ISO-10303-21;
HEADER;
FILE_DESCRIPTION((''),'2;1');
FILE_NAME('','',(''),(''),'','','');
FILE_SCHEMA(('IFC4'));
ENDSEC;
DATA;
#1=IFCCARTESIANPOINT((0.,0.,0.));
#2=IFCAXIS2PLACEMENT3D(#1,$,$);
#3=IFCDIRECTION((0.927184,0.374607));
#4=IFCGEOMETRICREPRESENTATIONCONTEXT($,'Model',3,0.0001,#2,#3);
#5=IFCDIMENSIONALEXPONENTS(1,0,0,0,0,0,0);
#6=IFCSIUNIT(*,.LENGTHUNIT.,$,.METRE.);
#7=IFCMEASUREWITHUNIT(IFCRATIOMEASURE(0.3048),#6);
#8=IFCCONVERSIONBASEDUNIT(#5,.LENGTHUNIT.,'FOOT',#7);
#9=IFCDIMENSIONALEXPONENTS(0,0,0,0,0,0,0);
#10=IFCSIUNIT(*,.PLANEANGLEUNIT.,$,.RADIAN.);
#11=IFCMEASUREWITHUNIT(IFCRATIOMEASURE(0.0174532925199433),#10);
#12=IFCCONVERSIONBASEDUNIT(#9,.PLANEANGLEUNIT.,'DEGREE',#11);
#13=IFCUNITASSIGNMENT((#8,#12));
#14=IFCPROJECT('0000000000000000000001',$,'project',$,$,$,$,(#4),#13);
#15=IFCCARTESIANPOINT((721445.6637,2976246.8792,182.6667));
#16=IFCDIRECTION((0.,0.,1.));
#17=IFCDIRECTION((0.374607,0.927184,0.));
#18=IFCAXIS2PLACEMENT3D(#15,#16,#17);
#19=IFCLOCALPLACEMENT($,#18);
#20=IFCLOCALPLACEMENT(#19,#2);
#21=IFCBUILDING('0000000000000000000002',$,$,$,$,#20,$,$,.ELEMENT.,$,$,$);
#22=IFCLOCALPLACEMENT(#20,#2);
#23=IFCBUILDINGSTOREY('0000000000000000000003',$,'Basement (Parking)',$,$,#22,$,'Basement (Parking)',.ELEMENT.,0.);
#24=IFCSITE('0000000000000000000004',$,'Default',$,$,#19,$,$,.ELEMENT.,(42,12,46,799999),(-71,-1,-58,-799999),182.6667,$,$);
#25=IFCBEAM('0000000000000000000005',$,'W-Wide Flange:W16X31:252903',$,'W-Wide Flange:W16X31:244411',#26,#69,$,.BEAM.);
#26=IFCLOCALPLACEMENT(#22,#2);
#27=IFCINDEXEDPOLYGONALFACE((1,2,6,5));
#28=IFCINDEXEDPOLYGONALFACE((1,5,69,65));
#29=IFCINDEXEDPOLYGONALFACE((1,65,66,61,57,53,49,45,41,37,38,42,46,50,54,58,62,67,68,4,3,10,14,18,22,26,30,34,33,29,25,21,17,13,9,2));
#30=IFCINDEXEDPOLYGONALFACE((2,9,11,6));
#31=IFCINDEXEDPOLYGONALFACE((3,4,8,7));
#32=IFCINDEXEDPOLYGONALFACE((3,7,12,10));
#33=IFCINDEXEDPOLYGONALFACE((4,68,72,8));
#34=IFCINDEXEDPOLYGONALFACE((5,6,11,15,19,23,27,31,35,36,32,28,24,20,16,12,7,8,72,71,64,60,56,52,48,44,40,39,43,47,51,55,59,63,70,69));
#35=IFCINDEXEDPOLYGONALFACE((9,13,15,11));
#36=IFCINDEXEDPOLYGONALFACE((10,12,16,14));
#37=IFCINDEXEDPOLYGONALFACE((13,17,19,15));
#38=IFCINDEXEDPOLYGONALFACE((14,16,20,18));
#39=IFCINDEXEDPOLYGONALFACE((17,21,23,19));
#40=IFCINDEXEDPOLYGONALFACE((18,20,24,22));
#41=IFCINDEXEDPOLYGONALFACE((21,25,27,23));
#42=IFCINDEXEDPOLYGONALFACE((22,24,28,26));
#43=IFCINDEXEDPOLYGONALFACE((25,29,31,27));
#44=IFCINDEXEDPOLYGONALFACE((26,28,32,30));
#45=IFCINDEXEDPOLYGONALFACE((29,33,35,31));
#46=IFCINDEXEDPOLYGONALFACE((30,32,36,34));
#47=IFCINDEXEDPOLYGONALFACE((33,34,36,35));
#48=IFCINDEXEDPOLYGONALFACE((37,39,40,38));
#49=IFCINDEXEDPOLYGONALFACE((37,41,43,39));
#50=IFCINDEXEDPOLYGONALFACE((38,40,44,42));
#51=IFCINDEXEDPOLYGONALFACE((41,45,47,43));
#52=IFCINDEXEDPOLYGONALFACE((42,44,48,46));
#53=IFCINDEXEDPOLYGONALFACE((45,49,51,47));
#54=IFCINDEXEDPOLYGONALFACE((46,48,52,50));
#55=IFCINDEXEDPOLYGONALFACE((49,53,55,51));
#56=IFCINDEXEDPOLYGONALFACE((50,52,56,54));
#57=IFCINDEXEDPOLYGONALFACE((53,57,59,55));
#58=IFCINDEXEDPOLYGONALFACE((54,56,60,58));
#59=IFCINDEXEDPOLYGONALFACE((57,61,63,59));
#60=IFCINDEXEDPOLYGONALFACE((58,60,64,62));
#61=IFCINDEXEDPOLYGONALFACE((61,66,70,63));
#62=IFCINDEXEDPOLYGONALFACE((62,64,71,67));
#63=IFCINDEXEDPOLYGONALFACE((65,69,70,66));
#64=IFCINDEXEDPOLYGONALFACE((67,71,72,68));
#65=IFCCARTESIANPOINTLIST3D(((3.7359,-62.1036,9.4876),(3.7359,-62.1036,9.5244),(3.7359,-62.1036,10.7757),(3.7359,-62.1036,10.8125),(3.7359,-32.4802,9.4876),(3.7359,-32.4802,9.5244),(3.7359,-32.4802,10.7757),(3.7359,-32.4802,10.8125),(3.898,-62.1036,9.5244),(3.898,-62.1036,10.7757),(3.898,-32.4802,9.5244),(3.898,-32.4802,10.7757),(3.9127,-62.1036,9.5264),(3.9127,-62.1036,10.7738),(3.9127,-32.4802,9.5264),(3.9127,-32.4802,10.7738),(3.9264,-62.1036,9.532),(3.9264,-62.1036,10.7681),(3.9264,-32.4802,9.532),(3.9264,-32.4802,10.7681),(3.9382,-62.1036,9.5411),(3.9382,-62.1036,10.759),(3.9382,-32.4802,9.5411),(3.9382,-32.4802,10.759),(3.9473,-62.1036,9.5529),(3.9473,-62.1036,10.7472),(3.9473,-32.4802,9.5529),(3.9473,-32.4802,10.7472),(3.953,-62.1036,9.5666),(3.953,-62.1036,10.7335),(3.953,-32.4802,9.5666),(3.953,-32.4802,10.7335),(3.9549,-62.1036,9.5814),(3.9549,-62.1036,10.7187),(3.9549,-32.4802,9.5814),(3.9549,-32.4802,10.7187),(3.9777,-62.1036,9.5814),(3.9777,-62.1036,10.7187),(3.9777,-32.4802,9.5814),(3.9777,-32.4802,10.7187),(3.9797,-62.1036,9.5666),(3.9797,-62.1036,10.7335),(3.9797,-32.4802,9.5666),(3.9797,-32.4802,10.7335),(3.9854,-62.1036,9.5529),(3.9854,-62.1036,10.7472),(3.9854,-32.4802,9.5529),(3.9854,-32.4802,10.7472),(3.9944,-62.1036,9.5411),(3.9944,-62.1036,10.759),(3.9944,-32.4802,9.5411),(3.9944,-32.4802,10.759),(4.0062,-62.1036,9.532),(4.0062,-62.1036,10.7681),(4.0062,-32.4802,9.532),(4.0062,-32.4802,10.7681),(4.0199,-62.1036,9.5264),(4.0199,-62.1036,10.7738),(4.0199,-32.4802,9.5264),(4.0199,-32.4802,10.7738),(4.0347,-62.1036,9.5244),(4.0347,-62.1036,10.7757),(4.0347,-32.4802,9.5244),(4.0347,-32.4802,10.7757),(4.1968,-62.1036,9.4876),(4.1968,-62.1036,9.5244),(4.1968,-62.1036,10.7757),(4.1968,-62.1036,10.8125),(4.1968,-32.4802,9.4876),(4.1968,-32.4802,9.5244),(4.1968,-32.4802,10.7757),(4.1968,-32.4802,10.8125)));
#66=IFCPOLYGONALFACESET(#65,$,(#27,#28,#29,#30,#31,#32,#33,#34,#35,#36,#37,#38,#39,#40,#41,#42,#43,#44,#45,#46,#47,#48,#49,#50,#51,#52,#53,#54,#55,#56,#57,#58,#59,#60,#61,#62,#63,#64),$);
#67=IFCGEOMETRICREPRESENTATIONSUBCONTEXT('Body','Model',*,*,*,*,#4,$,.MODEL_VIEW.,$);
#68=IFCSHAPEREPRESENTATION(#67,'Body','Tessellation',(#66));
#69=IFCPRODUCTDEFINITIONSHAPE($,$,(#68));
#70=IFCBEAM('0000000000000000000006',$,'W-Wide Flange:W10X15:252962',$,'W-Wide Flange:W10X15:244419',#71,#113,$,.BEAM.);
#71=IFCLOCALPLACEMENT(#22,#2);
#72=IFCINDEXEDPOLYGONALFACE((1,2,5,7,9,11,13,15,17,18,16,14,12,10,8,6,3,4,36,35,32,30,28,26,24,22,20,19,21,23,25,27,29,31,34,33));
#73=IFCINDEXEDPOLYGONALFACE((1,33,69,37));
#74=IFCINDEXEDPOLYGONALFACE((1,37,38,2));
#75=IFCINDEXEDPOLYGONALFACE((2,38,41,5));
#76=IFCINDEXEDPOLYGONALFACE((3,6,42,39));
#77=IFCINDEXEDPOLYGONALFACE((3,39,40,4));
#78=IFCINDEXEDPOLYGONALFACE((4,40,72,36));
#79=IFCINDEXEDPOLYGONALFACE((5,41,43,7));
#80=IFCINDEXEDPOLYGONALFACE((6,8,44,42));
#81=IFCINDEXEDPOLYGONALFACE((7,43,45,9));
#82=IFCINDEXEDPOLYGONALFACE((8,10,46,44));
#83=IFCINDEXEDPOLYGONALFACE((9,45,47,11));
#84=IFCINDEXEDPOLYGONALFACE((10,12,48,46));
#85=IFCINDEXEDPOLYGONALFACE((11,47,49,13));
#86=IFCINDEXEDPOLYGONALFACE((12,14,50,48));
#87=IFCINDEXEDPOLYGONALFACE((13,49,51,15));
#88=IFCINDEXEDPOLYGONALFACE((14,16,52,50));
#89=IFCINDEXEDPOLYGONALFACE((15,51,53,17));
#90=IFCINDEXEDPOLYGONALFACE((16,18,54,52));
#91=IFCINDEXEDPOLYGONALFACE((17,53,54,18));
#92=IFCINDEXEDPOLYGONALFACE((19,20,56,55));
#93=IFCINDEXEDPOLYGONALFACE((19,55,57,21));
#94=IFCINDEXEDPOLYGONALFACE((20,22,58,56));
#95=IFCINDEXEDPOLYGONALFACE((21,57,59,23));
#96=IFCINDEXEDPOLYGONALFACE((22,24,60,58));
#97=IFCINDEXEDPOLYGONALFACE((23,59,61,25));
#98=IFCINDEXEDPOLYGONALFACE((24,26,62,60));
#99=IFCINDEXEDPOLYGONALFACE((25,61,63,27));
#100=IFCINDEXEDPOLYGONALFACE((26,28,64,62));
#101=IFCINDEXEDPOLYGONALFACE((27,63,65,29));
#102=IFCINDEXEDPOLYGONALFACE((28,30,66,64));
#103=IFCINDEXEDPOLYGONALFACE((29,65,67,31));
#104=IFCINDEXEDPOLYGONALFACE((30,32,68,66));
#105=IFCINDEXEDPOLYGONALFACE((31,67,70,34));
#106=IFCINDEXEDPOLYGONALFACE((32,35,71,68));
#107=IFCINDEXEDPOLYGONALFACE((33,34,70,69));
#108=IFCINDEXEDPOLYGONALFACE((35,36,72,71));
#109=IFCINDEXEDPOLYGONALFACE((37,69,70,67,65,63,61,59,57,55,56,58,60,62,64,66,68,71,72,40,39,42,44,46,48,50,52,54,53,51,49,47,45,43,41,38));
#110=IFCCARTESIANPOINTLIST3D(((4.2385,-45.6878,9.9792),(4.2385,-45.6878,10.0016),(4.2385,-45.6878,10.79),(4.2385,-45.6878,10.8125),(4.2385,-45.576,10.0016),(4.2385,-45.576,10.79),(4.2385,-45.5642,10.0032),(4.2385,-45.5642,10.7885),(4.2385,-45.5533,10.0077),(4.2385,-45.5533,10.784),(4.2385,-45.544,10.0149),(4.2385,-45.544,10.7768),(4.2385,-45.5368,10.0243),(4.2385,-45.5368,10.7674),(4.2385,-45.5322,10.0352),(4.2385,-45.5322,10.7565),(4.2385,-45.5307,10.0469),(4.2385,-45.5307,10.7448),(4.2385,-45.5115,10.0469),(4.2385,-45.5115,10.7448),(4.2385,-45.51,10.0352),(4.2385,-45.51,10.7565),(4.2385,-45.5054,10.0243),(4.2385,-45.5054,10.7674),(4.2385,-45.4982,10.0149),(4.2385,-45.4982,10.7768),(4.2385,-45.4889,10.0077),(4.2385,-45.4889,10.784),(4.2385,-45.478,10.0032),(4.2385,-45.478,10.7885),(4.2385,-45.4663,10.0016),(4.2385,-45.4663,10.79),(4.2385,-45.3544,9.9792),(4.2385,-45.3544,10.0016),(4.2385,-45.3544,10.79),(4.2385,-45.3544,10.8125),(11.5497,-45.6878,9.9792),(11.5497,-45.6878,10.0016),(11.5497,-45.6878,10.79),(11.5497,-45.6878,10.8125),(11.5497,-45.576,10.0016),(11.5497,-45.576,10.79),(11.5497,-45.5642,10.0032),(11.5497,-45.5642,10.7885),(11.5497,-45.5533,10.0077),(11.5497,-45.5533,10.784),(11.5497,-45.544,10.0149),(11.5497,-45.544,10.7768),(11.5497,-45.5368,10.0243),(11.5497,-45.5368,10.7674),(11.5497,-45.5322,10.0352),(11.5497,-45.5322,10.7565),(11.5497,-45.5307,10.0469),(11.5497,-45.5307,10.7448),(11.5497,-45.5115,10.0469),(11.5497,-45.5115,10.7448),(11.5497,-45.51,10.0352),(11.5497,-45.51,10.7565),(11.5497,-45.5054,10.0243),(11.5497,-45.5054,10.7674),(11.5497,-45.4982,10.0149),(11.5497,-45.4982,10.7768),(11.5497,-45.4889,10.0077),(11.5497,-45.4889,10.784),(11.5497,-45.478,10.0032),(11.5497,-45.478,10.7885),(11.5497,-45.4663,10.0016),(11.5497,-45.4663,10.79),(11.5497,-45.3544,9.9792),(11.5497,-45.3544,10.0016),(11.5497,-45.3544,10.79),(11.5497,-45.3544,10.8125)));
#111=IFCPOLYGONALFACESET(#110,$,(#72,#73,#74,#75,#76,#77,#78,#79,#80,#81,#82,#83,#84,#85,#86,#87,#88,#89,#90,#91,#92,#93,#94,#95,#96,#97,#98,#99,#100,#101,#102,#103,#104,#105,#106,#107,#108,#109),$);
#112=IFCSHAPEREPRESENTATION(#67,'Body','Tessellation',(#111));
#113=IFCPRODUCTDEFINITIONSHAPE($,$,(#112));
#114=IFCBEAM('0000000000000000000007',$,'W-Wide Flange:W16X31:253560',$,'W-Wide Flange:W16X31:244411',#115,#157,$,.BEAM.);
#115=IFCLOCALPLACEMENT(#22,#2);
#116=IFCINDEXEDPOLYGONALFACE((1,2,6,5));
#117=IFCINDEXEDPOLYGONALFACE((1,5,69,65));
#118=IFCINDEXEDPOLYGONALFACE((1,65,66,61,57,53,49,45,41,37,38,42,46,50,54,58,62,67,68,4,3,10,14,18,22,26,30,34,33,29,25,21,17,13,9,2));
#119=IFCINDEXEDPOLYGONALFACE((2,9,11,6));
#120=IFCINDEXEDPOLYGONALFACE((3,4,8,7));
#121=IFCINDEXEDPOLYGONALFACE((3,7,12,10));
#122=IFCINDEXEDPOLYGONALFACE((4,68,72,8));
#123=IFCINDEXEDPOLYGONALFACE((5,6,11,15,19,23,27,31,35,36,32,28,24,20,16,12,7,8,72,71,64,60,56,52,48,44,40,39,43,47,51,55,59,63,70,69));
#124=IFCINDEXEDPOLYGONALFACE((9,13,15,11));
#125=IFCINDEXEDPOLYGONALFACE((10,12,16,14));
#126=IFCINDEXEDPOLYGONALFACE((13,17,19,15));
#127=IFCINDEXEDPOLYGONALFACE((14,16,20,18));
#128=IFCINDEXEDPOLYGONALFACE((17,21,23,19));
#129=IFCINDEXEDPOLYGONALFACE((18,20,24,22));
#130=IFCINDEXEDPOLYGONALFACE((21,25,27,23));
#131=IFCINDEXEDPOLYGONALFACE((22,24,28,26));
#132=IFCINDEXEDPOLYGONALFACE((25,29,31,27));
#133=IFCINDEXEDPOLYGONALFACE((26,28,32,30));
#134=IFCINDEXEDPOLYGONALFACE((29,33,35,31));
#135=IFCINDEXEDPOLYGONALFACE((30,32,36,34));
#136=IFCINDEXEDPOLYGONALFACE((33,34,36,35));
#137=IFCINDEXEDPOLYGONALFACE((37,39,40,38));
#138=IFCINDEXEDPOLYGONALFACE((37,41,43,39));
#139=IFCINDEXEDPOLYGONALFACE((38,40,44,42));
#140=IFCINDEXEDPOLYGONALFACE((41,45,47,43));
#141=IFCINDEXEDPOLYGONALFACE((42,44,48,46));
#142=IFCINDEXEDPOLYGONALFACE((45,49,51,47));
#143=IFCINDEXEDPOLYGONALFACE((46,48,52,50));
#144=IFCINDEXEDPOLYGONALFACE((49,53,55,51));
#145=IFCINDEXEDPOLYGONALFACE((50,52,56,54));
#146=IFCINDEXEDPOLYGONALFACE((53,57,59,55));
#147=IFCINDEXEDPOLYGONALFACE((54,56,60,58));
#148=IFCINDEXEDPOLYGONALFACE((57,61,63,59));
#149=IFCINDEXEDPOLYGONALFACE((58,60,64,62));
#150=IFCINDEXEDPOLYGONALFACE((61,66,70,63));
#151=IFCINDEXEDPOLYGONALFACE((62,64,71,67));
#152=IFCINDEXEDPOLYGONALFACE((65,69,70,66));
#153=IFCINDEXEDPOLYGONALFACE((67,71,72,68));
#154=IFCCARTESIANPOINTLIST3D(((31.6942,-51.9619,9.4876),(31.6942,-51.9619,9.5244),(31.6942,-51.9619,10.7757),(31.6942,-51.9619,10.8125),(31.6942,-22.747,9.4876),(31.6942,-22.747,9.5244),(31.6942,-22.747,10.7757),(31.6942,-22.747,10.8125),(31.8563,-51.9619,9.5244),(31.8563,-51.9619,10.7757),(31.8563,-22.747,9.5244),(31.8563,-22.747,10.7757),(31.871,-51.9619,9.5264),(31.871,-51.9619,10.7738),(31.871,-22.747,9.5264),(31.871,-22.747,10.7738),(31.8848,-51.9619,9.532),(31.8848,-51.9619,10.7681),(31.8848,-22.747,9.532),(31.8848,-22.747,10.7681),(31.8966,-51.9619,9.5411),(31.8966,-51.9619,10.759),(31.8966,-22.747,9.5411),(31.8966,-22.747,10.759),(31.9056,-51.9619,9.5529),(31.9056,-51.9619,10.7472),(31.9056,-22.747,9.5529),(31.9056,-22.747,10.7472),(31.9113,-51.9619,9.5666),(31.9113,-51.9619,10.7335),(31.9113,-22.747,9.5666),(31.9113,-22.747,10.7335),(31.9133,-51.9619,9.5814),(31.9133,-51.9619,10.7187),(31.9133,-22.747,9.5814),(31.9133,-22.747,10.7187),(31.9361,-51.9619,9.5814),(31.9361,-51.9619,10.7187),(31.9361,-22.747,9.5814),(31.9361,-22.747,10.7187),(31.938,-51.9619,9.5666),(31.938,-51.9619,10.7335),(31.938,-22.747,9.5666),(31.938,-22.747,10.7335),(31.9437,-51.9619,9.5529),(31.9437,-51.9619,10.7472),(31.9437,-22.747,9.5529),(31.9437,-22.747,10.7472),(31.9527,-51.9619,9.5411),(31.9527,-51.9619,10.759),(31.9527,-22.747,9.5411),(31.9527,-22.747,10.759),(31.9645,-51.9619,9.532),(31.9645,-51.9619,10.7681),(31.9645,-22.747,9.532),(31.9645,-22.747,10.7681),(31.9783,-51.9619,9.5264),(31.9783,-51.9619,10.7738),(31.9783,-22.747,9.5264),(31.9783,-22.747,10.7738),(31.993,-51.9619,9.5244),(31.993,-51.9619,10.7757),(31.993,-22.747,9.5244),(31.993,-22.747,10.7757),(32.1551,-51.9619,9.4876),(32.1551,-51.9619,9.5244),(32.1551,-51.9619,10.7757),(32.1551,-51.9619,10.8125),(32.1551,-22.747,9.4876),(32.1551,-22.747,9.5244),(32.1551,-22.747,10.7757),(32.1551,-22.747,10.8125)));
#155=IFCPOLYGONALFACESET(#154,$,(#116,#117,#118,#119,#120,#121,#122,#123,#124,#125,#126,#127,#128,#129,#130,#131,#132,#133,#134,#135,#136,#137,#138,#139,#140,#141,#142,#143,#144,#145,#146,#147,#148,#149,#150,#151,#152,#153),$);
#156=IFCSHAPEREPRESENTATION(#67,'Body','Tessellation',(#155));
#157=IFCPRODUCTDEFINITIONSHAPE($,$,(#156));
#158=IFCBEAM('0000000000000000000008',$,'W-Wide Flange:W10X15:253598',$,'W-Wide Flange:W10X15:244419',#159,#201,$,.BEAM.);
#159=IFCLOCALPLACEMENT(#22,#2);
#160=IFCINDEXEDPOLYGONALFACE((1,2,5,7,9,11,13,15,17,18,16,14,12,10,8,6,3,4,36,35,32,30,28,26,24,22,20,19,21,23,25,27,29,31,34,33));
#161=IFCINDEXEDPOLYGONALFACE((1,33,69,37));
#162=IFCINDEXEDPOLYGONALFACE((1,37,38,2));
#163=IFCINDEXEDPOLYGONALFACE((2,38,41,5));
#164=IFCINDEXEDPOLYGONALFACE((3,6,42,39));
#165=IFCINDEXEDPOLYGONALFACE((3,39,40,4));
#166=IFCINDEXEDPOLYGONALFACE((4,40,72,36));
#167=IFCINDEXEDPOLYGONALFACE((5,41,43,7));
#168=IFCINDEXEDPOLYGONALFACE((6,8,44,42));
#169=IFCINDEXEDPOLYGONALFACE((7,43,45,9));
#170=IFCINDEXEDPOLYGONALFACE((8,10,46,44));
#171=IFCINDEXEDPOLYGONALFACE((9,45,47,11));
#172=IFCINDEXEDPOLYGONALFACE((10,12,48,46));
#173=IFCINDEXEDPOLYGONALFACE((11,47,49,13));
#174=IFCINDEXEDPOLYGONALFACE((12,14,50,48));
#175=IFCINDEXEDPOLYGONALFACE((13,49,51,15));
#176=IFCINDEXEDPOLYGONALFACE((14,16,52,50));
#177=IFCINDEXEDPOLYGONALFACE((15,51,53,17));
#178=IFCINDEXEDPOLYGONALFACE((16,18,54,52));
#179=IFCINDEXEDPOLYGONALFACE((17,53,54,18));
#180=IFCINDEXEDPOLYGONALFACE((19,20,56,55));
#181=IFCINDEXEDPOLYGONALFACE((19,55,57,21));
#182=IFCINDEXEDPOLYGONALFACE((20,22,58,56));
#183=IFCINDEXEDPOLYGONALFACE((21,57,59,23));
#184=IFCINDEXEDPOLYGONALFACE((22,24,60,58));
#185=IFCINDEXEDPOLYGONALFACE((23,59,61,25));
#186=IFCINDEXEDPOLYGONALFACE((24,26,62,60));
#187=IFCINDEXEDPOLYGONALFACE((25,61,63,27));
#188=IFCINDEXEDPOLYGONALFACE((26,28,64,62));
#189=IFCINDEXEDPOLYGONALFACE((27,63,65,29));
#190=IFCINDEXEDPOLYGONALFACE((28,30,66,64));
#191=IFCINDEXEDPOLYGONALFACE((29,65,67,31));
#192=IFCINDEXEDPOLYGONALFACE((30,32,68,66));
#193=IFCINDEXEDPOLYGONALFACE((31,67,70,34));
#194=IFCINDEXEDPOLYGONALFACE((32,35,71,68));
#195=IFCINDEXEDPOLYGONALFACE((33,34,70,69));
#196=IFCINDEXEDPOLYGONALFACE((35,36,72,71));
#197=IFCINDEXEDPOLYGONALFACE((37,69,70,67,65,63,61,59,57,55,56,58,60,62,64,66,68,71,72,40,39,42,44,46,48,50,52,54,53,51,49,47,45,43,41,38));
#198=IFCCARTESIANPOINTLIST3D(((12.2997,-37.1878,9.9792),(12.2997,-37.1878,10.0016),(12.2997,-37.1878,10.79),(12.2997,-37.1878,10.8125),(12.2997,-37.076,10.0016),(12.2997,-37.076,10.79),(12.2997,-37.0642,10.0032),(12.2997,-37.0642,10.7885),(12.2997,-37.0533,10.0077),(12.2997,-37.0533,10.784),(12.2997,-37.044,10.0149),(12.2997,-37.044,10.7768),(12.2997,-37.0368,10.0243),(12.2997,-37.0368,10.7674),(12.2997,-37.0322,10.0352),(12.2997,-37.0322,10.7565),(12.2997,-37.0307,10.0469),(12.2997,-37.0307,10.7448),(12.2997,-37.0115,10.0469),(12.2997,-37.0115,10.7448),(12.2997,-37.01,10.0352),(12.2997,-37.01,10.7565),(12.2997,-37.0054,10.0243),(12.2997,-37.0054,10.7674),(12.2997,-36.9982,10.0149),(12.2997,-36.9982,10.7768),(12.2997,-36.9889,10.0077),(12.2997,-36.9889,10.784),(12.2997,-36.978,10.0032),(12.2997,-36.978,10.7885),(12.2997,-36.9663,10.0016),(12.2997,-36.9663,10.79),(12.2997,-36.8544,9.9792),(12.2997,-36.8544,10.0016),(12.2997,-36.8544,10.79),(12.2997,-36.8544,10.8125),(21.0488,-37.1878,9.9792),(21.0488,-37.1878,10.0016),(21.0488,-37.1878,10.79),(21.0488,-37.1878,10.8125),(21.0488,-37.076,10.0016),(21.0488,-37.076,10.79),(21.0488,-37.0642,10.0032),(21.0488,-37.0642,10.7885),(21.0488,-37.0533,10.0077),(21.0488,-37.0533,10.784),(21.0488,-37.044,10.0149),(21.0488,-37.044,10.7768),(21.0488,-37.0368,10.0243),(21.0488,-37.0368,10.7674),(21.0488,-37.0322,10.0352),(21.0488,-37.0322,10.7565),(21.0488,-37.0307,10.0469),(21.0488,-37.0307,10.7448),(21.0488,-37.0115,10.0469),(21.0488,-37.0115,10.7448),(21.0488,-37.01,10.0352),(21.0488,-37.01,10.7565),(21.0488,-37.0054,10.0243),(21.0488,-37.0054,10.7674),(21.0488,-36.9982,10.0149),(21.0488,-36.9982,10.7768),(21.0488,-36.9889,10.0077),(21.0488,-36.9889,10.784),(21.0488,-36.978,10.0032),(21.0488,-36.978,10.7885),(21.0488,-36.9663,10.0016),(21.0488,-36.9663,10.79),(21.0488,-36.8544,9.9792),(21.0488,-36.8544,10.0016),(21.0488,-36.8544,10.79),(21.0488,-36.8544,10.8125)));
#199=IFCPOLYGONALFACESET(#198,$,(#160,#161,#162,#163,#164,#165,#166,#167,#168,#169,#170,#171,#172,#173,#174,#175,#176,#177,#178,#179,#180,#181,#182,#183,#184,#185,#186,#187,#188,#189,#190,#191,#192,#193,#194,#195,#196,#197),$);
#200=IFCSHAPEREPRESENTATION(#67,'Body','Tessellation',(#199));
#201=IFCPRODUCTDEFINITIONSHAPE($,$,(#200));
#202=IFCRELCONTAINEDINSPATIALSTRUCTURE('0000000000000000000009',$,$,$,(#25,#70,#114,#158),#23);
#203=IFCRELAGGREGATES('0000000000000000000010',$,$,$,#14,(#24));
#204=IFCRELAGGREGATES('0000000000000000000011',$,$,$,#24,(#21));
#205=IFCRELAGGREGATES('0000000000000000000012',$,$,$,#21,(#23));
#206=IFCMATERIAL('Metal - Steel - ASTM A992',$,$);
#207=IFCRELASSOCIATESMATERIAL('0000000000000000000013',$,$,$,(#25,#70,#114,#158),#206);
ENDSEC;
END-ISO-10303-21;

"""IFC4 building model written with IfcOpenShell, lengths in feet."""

from ifc_helpers import new_model, entity, si_unit, converted_unit, direction, frame, frame_2d, origin, place, context, subcontext, project, spatial, i_section, extrude, material, element, save


model = new_model("IFC4")

# Units and contexts
model_context = context("Model", 3, precision=0.0001, world=origin(), true_north=direction((0.927184, 0.374607)))
body_context = subcontext(model_context, "Body", "Model", "MODEL_VIEW")
ifc_project = project(units=[converted_unit("LENGTHUNIT", "FOOT", entity("IfcRatioMeasure", 0.3048), si_unit("LENGTHUNIT", "METRE"), dimensions=[1, 0, 0, 0, 0, 0, 0]), converted_unit("PLANEANGLEUNIT", "DEGREE", entity("IfcRatioMeasure", 0.0174532925199433), si_unit("PLANEANGLEUNIT", "RADIAN"), dimensions=[0, 0, 0, 0, 0, 0, 0])], contexts=[model_context])

# Site, building, storey
site_placement = place(None, frame((721445.6637, 2976246.8792, 182.6667), z_axis=(0.0, 0.0, 1.0), x_axis=(0.374607, 0.927184, 0.0)))
site = spatial("IfcSite", under=ifc_project, at=site_placement, Name="Default", CompositionType="ELEMENT", RefLatitude=(42, 12, 46, 799999), RefLongitude=(-71, -1, -58, -799999), RefElevation=182.6667)
building_placement = place(site_placement, origin())
building = spatial("IfcBuilding", under=site, at=building_placement, CompositionType="ELEMENT")
storey_placement = place(building_placement, origin())
storey = spatial("IfcBuildingStorey", under=building, at=storey_placement, Name="Basement (Parking)", LongName="Basement (Parking)", CompositionType="ELEMENT", Elevation=0.0)

# Shared definitions
ifc_material_1 = material(Name="Metal - Steel - ASTM A992")

# Beams
beam_1_placement = place(storey_placement, frame((3.9663, -62.3961, 10.8125), z_axis=(0.0, 0.0, 1.0), x_axis=(0.0, 1.0, 0.0)))
element("IfcBeam", 1, at=beam_1_placement, inside=storey, material=ifc_material_1, Name="W-Wide Flange:W16X31:252903", ObjectType="W-Wide Flange:W16X31:244411", PredefinedType="BEAM", context=body_context, shape_type="SweptSolid", body=[
    extrude(i_section(OverallWidth=0.4609, OverallDepth=1.3249, WebThickness=0.0228, FlangeThickness=0.0368, FilletRadius=0.057, at=frame_2d((0.0, 0.0), x_axis=(0.0, 1.0))), frame((0.2925, 0.0, -0.6624), z_axis=(1.0, 0.0, 0.0), x_axis=(0.0, 0.0, -1.0)), (0.0, 0.0, 1.0), 29.6234),
])
beam_2_placement = place(storey_placement, frame((12.008, -45.5211, 10.8125), z_axis=(0.0, 0.0, 1.0), x_axis=(-1.0, 0.0, 0.0)))
element("IfcBeam", 2, at=beam_2_placement, inside=storey, material=ifc_material_1, Name="W-Wide Flange:W10X15:252962", ObjectType="W-Wide Flange:W10X15:244419", PredefinedType="BEAM", context=body_context, shape_type="SweptSolid", body=[
    extrude(i_section(OverallWidth=0.3333, OverallDepth=0.8333, WebThickness=0.0192, FlangeThickness=0.0225, FilletRadius=0.0452, at=frame_2d((0.0, 0.0), x_axis=(0.0, 1.0))), frame((0.4583, 0.0, -0.4167), z_axis=(1.0, 0.0, 0.0), x_axis=(0.0, 0.0, -1.0)), (0.0, 0.0, 1.0), 7.3112),
])
beam_3_placement = place(storey_placement, frame((31.9247, -52.3544, 10.8125), z_axis=(0.0, 0.0, 1.0), x_axis=(0.0, 1.0, 0.0)))
element("IfcBeam", 3, at=beam_3_placement, inside=storey, material=ifc_material_1, Name="W-Wide Flange:W16X31:253560", ObjectType="W-Wide Flange:W16X31:244411", PredefinedType="BEAM", context=body_context, shape_type="SweptSolid", body=[
    extrude(i_section(OverallWidth=0.4609, OverallDepth=1.3249, WebThickness=0.0228, FlangeThickness=0.0368, FilletRadius=0.057, at=frame_2d((0.0, 0.0), x_axis=(0.0, 1.0))), frame((0.3926, 0.0, -0.6624), z_axis=(1.0, 0.0, 0.0), x_axis=(0.0, 0.0, -1.0)), (0.0, 0.0, 1.0), 29.2148),
])
beam_4_placement = place(storey_placement, frame((12.008, -37.0211, 10.8125)))
element("IfcBeam", 4, at=beam_4_placement, inside=storey, material=ifc_material_1, Name="W-Wide Flange:W10X15:253598", ObjectType="W-Wide Flange:W10X15:244419", PredefinedType="BEAM", context=body_context, shape_type="SweptSolid", body=[
    extrude(i_section(OverallWidth=0.3333, OverallDepth=0.8333, WebThickness=0.0192, FlangeThickness=0.0225, FilletRadius=0.0452, at=frame_2d((0.0, 0.0), x_axis=(0.0, 1.0))), frame((0.2917, 0.0, -0.4167), z_axis=(1.0, 0.0, 0.0), x_axis=(0.0, 0.0, -1.0)), (0.0, 0.0, 1.0), 8.7492),
])

save(model, "model.ifc")
